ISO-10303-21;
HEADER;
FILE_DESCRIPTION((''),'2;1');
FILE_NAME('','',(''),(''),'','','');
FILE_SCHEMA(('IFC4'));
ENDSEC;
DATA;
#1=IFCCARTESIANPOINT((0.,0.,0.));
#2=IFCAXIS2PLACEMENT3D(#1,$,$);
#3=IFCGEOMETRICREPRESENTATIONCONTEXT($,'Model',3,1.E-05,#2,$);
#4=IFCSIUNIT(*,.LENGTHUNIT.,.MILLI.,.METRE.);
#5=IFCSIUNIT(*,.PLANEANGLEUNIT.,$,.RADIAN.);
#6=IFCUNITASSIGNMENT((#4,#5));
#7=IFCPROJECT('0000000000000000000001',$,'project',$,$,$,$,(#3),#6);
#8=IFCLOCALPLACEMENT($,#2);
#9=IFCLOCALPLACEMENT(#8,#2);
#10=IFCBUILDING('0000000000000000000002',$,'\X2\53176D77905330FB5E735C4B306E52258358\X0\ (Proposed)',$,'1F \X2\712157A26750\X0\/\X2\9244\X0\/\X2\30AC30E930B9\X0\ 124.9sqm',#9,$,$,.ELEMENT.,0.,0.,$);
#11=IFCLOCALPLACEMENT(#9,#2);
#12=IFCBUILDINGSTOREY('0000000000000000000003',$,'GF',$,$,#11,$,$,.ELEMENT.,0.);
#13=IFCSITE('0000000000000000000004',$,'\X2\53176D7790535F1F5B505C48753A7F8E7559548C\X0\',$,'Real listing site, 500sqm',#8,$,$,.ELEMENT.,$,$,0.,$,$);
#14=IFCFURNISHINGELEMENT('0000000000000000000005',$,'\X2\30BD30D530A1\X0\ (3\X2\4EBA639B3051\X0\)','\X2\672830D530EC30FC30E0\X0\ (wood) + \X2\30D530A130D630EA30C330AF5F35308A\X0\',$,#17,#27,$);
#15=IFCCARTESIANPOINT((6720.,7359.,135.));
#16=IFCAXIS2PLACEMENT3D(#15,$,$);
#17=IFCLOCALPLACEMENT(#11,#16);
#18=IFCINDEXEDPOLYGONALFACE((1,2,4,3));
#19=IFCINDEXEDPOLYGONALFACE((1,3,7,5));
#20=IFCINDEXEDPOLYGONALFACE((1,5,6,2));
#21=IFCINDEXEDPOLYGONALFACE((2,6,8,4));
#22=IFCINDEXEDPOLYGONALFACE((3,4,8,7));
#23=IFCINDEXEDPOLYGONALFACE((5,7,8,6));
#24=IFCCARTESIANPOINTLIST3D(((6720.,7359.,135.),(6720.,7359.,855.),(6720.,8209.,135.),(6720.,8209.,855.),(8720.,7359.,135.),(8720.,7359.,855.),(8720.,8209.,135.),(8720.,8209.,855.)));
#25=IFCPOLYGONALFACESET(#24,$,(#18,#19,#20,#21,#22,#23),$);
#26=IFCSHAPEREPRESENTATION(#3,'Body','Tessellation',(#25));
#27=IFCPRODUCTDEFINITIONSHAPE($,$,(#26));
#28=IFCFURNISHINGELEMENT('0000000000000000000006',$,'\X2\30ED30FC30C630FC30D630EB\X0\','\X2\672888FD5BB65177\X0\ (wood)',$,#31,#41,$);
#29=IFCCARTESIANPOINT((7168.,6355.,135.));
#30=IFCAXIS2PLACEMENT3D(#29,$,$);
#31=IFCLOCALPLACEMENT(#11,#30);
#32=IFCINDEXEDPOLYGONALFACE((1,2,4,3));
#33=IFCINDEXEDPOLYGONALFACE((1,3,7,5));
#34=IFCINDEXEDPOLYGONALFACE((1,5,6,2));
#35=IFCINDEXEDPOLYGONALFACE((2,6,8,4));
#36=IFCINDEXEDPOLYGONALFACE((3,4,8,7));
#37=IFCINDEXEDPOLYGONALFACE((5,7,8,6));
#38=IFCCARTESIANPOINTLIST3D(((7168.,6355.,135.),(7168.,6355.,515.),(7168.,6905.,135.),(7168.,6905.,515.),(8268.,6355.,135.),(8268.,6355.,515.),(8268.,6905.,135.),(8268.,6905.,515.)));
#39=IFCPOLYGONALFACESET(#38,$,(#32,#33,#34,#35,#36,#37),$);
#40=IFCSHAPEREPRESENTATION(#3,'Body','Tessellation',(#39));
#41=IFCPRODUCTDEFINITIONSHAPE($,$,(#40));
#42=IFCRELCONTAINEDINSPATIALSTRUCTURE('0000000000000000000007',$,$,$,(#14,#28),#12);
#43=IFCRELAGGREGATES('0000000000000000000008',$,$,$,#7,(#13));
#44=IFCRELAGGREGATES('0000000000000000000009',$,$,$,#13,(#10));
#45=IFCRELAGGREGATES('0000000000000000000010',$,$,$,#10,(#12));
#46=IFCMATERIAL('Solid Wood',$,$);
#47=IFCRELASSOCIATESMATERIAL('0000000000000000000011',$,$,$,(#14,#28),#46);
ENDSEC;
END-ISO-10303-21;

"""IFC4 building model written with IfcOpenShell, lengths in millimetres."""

from ifc_helpers import new_model, si_unit, frame, frame_2d, origin, place, context, project, spatial, rectangle, extrude, material, element, save


model = new_model("IFC4")

# Units and contexts
model_context = context("Model", 3, precision=1e-05, world=origin())
ifc_project = project(units=[si_unit("LENGTHUNIT", "METRE", prefix="MILLI"), si_unit("PLANEANGLEUNIT", "RADIAN")], contexts=[model_context])

# Site, building, storey
site_placement = place(None, origin())
site = spatial("IfcSite", under=ifc_project, at=site_placement, Name="北海道弟子屈町美留和", ObjectType="Real listing site, 500sqm", CompositionType="ELEMENT", RefElevation=0.0)
building_placement = place(site_placement, origin())
building = spatial("IfcBuilding", under=site, at=building_placement, Name="北海道・平屋の別荘 (Proposed)", ObjectType="1F 無垢材/鉄/ガラス 124.9sqm", CompositionType="ELEMENT", ElevationOfRefHeight=0.0, ElevationOfTerrain=0.0)
storey_placement = place(building_placement, origin())
storey = spatial("IfcBuildingStorey", under=building, at=storey_placement, Name="GF", CompositionType="ELEMENT", Elevation=0.0)

# Shared definitions
ifc_material_1 = material(Name="Solid Wood")

# Furnishing elements
furnishing_1_placement = place(storey_placement, frame((6720.0, 7359.0, 135.0)))
element("IfcFurnishingElement", 1, at=furnishing_1_placement, inside=storey, material=ifc_material_1, Name="ソファ (3人掛け)", Description="木フレーム (wood) + ファブリック張り", context=model_context, shape_type="SweptSolid", body=[
    extrude(rectangle(XDim=2000.0, YDim=850.0, at=frame_2d((1000.0, 425.0))), frame((6720.0, 7359.0, 135.0)), (0.0, 0.0, 1.0), 720.0),
])
furnishing_2_placement = place(storey_placement, frame((7168.0, 6355.0, 135.0)))
element("IfcFurnishingElement", 2, at=furnishing_2_placement, inside=storey, material=ifc_material_1, Name="ローテーブル", Description="木製家具 (wood)", context=model_context, shape_type="SweptSolid", body=[
    extrude(rectangle(XDim=1100.0, YDim=550.0, at=frame_2d((550.0, 275.0))), frame((7168.0, 6355.0, 135.0)), (0.0, 0.0, 1.0), 380.0),
])

save(model, "model.ifc")
